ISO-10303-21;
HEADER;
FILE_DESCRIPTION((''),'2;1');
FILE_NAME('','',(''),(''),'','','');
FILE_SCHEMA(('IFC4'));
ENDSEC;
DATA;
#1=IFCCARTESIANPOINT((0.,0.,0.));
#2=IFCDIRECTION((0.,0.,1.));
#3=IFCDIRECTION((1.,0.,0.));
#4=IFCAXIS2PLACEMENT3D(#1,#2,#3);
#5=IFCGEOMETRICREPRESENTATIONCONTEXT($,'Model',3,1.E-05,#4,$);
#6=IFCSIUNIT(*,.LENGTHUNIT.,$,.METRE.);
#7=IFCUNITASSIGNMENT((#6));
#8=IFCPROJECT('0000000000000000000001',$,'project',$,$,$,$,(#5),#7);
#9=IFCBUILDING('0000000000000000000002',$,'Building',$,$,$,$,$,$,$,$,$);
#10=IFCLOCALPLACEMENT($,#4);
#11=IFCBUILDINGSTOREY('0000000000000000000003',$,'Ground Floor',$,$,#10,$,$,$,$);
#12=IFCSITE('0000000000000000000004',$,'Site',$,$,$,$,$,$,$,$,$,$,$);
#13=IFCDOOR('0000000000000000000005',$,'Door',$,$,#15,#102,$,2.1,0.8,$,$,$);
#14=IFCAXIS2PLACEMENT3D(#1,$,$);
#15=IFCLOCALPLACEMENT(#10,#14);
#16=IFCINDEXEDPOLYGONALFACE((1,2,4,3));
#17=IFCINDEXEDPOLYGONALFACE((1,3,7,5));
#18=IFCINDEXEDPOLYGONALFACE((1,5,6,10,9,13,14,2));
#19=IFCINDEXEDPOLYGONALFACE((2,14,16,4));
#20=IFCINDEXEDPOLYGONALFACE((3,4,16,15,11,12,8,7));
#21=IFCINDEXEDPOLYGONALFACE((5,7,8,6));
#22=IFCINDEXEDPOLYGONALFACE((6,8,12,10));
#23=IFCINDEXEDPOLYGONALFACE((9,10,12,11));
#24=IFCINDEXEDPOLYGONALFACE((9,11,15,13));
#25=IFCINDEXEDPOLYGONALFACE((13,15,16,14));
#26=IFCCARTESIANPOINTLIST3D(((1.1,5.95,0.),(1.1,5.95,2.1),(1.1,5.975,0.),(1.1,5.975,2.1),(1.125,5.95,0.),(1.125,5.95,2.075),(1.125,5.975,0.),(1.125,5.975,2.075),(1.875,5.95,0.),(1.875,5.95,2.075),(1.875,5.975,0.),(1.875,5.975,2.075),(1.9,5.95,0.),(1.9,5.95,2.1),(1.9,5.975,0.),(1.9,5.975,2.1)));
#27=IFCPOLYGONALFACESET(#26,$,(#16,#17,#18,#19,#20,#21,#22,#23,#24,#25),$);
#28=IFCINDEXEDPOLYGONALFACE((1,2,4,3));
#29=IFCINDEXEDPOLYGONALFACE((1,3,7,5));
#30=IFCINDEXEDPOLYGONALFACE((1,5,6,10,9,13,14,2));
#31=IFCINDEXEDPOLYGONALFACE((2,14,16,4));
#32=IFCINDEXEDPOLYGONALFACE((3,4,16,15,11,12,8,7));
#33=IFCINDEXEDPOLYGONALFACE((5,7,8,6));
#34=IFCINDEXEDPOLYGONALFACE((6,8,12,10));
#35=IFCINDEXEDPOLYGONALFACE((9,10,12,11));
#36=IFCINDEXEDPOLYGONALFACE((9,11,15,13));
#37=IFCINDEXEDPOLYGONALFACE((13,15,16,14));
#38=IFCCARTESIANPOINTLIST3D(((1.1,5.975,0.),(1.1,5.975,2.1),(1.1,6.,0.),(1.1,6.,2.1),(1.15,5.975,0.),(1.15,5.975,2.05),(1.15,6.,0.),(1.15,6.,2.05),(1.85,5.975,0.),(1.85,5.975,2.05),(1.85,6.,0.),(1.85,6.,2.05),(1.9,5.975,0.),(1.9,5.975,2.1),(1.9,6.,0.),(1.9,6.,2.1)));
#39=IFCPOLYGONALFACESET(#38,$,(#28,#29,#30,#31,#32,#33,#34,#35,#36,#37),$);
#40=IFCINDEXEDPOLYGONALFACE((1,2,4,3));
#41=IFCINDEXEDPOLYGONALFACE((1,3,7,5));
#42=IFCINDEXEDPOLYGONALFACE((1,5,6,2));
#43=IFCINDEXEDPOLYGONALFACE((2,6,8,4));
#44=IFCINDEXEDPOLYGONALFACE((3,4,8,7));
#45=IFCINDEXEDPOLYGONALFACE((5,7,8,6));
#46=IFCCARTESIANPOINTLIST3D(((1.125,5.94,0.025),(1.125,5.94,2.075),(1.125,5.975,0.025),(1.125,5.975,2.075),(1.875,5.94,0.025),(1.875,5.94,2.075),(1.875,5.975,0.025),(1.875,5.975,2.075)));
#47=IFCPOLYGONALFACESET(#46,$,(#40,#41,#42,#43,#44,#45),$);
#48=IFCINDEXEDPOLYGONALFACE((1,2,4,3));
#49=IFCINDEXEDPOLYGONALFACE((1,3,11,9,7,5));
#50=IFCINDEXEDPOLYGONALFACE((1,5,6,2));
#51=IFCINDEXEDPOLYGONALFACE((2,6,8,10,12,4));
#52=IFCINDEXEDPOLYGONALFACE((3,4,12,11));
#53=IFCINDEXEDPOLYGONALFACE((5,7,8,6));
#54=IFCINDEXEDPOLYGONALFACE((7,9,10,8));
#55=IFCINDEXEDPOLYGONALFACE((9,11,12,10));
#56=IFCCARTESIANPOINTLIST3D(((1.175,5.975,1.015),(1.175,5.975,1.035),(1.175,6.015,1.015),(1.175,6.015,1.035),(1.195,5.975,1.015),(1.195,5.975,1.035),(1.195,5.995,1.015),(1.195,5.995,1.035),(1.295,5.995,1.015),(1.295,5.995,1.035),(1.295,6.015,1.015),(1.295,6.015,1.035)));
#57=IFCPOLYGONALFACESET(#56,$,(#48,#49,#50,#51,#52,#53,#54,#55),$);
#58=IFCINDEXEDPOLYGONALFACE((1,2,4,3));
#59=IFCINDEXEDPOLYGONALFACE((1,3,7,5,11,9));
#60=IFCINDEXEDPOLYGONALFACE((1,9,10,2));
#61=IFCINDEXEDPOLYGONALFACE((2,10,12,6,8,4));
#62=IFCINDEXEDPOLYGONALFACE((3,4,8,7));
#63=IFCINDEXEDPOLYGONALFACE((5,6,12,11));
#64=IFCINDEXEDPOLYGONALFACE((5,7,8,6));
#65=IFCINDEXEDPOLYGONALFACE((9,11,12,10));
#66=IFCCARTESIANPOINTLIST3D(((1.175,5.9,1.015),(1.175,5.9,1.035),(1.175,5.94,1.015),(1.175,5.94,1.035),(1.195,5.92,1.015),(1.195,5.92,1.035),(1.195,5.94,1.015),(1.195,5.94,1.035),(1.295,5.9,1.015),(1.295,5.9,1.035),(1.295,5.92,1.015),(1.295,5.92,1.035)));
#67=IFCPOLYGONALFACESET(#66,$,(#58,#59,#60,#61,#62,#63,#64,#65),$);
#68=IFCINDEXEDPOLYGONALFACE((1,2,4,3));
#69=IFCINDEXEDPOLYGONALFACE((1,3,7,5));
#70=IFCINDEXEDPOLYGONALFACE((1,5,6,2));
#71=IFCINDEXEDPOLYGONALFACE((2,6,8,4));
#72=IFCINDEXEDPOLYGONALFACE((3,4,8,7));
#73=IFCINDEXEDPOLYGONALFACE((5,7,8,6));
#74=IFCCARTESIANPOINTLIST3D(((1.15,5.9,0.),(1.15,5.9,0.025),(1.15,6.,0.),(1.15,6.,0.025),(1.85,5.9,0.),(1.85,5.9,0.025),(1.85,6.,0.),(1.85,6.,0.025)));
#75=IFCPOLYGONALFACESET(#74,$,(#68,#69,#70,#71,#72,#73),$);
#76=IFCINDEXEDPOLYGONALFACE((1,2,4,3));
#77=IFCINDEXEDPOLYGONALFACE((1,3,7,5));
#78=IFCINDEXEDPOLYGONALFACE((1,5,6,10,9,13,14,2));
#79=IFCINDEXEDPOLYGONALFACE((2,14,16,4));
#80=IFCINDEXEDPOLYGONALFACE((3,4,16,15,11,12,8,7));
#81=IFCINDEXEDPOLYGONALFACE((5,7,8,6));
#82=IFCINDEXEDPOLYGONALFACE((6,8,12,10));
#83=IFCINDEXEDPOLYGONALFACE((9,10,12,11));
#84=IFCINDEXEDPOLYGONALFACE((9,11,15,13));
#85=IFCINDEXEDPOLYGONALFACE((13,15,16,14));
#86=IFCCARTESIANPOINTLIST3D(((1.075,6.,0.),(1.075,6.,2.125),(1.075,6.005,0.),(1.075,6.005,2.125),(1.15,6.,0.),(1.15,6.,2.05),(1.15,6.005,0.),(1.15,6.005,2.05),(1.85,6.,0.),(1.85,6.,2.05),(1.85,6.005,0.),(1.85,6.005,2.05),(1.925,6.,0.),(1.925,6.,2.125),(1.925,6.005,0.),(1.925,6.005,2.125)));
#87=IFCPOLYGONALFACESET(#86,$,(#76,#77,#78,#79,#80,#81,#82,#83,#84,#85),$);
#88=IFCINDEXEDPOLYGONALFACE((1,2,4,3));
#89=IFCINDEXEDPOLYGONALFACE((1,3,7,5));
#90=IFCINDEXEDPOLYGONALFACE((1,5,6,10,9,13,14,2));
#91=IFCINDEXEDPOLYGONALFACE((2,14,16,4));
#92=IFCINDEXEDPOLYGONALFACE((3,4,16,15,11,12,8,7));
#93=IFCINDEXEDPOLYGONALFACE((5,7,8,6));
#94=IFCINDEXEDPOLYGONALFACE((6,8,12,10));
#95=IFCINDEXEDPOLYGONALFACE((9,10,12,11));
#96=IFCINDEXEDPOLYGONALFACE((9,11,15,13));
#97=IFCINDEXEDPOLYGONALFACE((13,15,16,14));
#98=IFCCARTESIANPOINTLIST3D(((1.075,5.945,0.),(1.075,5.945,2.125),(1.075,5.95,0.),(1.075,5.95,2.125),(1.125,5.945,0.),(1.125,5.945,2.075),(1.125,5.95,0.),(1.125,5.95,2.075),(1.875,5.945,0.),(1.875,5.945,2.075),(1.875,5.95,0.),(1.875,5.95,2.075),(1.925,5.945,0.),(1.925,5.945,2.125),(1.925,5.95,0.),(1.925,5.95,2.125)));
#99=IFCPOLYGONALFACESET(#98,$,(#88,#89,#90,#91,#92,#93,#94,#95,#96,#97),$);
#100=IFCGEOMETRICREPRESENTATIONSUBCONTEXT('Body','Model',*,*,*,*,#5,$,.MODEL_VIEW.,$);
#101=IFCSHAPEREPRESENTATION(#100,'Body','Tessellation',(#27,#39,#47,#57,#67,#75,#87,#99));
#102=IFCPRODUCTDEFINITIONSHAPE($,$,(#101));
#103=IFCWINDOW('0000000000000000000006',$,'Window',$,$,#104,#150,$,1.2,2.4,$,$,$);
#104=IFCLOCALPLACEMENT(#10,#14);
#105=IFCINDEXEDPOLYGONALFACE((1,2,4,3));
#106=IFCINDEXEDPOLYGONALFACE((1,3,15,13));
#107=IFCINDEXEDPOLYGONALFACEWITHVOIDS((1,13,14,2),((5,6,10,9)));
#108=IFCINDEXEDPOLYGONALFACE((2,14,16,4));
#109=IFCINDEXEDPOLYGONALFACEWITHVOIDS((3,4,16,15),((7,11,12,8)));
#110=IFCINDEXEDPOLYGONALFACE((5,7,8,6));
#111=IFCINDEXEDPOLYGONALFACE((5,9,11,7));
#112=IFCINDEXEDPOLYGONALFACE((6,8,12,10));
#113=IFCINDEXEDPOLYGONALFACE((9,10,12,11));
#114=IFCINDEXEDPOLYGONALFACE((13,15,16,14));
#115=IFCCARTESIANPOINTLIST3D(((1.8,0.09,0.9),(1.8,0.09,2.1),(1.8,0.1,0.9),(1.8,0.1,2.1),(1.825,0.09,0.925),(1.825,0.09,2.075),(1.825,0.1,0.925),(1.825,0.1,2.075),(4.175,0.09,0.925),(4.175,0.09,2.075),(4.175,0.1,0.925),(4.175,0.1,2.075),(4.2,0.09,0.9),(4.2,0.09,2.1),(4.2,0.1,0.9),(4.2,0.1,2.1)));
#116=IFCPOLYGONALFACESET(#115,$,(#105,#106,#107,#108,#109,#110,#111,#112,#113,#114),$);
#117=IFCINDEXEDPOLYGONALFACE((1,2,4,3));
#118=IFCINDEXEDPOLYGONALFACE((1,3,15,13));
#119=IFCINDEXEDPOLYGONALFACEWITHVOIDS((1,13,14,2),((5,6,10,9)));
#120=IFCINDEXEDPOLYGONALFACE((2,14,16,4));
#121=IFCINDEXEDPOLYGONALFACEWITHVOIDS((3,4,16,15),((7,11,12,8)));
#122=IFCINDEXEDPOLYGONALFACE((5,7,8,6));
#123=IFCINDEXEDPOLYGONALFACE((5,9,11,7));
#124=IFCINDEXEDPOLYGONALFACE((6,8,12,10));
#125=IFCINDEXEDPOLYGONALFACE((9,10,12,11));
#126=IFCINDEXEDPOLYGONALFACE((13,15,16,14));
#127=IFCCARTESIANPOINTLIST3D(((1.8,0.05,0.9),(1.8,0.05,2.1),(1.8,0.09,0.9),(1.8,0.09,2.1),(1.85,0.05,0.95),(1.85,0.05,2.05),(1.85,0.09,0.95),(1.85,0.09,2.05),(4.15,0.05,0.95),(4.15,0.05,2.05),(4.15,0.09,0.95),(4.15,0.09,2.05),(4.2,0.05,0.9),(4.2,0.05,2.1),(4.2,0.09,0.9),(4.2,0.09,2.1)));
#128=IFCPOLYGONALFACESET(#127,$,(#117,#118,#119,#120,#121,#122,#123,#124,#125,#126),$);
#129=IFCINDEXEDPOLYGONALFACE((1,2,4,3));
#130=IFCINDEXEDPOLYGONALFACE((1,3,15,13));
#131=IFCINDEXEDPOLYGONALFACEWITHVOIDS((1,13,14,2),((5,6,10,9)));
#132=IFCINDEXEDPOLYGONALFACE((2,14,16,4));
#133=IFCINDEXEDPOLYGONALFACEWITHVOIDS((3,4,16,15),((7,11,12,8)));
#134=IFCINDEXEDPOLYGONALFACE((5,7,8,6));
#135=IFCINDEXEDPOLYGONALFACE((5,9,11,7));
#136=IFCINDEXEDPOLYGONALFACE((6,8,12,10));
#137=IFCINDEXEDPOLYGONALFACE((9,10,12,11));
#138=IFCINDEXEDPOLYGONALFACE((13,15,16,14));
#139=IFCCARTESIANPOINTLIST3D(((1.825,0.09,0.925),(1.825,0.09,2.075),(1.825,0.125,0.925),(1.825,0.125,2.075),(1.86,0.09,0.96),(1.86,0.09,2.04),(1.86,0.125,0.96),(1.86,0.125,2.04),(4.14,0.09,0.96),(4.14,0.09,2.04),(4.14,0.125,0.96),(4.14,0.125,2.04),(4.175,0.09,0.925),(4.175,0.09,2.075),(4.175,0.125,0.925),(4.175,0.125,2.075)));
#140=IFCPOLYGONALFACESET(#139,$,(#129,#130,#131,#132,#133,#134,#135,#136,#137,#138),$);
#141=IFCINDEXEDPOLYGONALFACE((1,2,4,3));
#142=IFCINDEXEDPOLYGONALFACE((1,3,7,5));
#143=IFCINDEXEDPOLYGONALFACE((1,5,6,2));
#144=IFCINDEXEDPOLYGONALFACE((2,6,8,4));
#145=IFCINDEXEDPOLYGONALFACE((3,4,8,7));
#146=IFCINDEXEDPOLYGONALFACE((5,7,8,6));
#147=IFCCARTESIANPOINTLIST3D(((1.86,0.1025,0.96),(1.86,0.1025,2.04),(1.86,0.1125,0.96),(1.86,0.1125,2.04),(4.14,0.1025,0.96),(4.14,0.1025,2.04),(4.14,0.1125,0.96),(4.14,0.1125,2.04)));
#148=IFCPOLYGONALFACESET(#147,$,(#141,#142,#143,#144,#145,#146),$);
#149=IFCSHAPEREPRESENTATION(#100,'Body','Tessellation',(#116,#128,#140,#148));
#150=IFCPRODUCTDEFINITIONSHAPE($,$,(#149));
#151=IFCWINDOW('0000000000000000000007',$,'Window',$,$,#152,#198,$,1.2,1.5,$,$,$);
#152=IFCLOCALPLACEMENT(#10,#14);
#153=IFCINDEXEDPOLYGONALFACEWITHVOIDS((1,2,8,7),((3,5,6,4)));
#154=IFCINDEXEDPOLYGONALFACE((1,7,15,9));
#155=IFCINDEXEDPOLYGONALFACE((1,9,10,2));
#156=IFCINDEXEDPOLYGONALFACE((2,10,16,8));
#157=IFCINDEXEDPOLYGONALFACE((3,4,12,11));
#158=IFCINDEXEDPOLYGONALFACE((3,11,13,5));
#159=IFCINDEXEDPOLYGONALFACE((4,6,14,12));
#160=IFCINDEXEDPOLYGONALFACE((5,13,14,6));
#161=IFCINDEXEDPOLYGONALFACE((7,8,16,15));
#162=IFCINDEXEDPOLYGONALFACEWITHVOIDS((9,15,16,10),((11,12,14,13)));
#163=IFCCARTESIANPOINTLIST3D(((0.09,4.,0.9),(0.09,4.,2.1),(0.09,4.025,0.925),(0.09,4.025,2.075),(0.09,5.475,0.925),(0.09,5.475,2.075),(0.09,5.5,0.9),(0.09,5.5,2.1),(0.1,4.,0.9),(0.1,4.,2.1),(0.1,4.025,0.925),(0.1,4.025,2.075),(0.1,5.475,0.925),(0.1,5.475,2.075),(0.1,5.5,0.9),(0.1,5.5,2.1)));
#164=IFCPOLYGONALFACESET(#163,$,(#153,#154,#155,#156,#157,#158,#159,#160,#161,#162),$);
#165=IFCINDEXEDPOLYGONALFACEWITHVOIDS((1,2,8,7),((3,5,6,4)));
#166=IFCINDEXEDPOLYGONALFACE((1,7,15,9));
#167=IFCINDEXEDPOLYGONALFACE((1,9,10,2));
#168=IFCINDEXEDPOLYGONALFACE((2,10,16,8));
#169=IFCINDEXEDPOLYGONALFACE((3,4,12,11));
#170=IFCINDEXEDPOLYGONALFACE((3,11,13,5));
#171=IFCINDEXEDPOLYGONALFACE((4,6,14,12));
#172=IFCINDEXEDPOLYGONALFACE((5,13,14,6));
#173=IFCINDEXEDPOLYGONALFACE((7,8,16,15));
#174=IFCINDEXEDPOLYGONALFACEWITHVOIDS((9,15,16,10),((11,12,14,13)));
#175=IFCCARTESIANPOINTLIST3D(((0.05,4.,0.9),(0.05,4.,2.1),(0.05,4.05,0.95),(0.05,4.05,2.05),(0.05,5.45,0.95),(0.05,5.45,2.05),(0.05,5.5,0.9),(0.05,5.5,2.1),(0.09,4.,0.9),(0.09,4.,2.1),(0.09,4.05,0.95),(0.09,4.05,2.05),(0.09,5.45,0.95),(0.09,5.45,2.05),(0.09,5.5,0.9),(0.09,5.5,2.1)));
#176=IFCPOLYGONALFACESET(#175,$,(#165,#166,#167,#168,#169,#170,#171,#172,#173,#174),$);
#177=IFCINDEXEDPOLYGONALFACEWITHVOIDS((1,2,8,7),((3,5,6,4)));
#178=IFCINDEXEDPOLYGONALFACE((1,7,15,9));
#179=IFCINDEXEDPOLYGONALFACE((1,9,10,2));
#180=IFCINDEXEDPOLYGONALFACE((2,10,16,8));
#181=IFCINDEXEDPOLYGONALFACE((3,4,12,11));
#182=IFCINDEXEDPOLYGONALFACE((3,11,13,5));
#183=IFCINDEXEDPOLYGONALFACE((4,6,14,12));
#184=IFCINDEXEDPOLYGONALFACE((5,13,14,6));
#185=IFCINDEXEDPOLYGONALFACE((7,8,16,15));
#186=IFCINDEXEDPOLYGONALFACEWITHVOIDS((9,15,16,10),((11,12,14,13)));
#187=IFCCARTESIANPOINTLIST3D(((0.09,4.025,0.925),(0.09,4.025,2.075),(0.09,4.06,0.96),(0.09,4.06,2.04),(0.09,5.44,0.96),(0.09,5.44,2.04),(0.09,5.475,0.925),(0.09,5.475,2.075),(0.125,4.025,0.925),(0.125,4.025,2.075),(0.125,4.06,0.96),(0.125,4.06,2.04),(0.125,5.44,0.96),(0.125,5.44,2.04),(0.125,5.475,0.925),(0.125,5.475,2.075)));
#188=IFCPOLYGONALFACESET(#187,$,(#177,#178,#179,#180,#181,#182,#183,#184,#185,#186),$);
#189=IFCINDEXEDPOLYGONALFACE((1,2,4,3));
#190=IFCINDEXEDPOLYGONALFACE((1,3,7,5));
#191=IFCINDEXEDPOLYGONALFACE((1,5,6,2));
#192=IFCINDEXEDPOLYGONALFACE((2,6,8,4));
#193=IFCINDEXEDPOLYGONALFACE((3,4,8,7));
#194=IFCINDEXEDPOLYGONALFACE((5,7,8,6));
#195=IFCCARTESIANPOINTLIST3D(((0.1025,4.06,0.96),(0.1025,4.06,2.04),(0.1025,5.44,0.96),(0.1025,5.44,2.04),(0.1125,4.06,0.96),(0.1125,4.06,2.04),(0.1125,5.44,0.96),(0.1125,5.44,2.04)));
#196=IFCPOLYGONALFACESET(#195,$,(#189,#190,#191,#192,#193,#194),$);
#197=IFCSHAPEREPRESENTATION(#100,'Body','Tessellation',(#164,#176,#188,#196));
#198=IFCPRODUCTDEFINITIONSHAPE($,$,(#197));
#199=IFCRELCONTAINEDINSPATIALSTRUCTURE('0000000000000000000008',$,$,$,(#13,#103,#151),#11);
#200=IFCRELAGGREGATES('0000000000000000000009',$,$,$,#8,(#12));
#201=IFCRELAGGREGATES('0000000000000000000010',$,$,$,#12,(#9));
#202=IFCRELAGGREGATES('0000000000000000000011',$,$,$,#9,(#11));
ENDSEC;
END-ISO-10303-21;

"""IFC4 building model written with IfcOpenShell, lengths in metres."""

from ifc_helpers import new_model, si_unit, frame, origin_with_axes, place, context, subcontext, project, spatial, line, indexed_curve, outline, extrude, element, save


model = new_model("IFC4")

# Units and contexts
model_context = context("Model", 3, precision=1e-05, world=origin_with_axes())
body_context = subcontext(model_context, "Body", "Model", "MODEL_VIEW")
ifc_project = project(units=[si_unit("LENGTHUNIT", "METRE")], contexts=[model_context])

# Site, building, storey
site = spatial("IfcSite", under=ifc_project, Name="Site")
building = spatial("IfcBuilding", under=site, Name="Building")
storey_placement = place(None, origin_with_axes())
storey = spatial("IfcBuildingStorey", under=building, at=storey_placement, Name="Ground Floor")

# Door
door_1_placement = place(storey_placement, frame((1.9, 6.0, 0.0), z_axis=(0.0, 0.0, 1.0), x_axis=(-1.0, 0.0, 0.0)))
element("IfcDoor", 1, at=door_1_placement, inside=storey, Name="Door", OverallHeight=2.1, OverallWidth=0.8, context=body_context, shape_type="SweptSolid", body=[
    extrude(outline(indexed_curve([(0.0, 0.0), (0.0, 2.1), (0.8, 2.1), (0.8, 0.0), (0.775, 0.0), (0.775, 2.075), (0.025, 2.075), (0.025, 0.0)], segments=[line(1, 2, 3, 4, 5, 6, 7, 8, 1)])), frame((0.0, 0.025, 0.0), z_axis=(0.0, -1.0, 0.0), x_axis=(1.0, 0.0, 0.0)), (0.0, 0.0, -1.0), 0.025),
    extrude(outline(indexed_curve([(0.0, 0.0), (0.0, 2.1), (0.8, 2.1), (0.8, 0.0), (0.75, 0.0), (0.75, 2.05), (0.05, 2.05), (0.05, 0.0)], segments=[line(1, 2, 3, 4, 5, 6, 7, 8, 1)])), frame((0.0, 0.0, 0.0), z_axis=(0.0, -1.0, 0.0), x_axis=(1.0, 0.0, 0.0)), (0.0, 0.0, -1.0), 0.025),
    extrude(outline(indexed_curve([(0.0, 0.0), (0.75, 0.0), (0.75, 0.035), (0.0, 0.035)], segments=[line(1, 2, 3, 4, 1)])), frame((0.025, 0.025, 0.025), z_axis=(0.0, 0.0, 1.0), x_axis=(1.0, 0.0, 0.0)), (0.0, 0.0, 1.0), 2.05),
    extrude(outline(indexed_curve([(0.0, 0.0), (0.0, -0.04), (-0.12, -0.04), (-0.12, -0.02), (-0.02, -0.02), (-0.02, 0.0)], segments=[line(1, 2, 3, 4, 5, 6, 1)])), frame((0.725, 0.025, 1.015), z_axis=(0.0, 0.0, 1.0), x_axis=(1.0, 0.0, 0.0)), (0.0, 0.0, 1.0), 0.02),
    extrude(outline(indexed_curve([(0.0, 0.0), (0.0, 0.04), (-0.12, 0.04), (-0.12, 0.02), (-0.02, 0.02), (-0.02, 0.0)], segments=[line(1, 2, 3, 4, 5, 6, 1)])), frame((0.725, 0.06, 1.015), z_axis=(0.0, 0.0, 1.0), x_axis=(1.0, 0.0, 0.0)), (0.0, 0.0, 1.0), 0.02),
    extrude(outline(indexed_curve([(0.0, 0.0), (0.7, 0.0), (0.7, 0.1), (0.0, 0.1)], segments=[line(1, 2, 3, 4, 1)])), frame((0.05, 0.0, 0.0), z_axis=(0.0, 0.0, 1.0), x_axis=(1.0, 0.0, 0.0)), (0.0, 0.0, 1.0), 0.025),
    extrude(outline(indexed_curve([(0.0, 0.0), (0.0, 2.125), (0.85, 2.125), (0.85, 0.0), (0.775, 0.0), (0.775, 2.05), (0.075, 2.05), (0.075, 0.0)], segments=[line(1, 2, 3, 4, 5, 6, 7, 8, 1)])), frame((-0.025, -0.005, 0.0), z_axis=(0.0, -1.0, 0.0), x_axis=(1.0, 0.0, 0.0)), (0.0, 0.0, -1.0), 0.005),
    extrude(outline(indexed_curve([(0.0, 0.0), (0.0, 2.125), (0.85, 2.125), (0.85, 0.0), (0.8, 0.0), (0.8, 2.075), (0.05, 2.075), (0.05, 0.0)], segments=[line(1, 2, 3, 4, 5, 6, 7, 8, 1)])), frame((-0.025, 0.05, 0.0), z_axis=(0.0, -1.0, 0.0), x_axis=(1.0, 0.0, 0.0)), (0.0, 0.0, -1.0), 0.005),
])

# Windows
window_1_placement = place(storey_placement, frame((1.8, 0.0, 0.9), z_axis=(0.0, 0.0, 1.0), x_axis=(1.0, 0.0, 0.0)))
element("IfcWindow", 2, at=window_1_placement, inside=storey, Name="Window", OverallHeight=1.2, OverallWidth=2.4, context=body_context, shape_type="SweptSolid", body=[
    extrude(outline(indexed_curve([(0.0, 0.0), (2.4, 0.0), (2.4, 1.2), (0.0, 1.2)], segments=[line(1, 2, 3, 4, 1)]), holes=[indexed_curve([(0.025, 0.025), (2.375, 0.025), (2.375, 1.175), (0.025, 1.175)], segments=[line(1, 2, 3, 4, 1)])]), frame((0.0, 0.09, 0.0), z_axis=(0.0, -1.0, 0.0), x_axis=(1.0, 0.0, 0.0)), (0.0, 0.0, -1.0), 0.01),
    extrude(outline(indexed_curve([(0.0, 0.0), (2.4, 0.0), (2.4, 1.2), (0.0, 1.2)], segments=[line(1, 2, 3, 4, 1)]), holes=[indexed_curve([(0.05, 0.05), (2.35, 0.05), (2.35, 1.15), (0.05, 1.15)], segments=[line(1, 2, 3, 4, 1)])]), frame((0.0, 0.05, 0.0), z_axis=(0.0, -1.0, 0.0), x_axis=(1.0, 0.0, 0.0)), (0.0, 0.0, -1.0), 0.04),
    extrude(outline(indexed_curve([(0.0, 0.0), (2.35, 0.0), (2.35, 1.15), (0.0, 1.15)], segments=[line(1, 2, 3, 4, 1)]), holes=[indexed_curve([(0.035, 0.035), (2.315, 0.035), (2.315, 1.115), (0.035, 1.115)], segments=[line(1, 2, 3, 4, 1)])]), frame((0.025, 0.09, 0.025), z_axis=(0.0, -1.0, 0.0), x_axis=(1.0, 0.0, 0.0)), (0.0, 0.0, -1.0), 0.035),
    extrude(outline(indexed_curve([(0.035, 0.035), (2.315, 0.035), (2.315, 1.115), (0.035, 1.115)], segments=[line(1, 2, 3, 4, 1)])), frame((0.025, 0.1025, 0.025), z_axis=(0.0, -1.0, 0.0), x_axis=(1.0, 0.0, 0.0)), (0.0, 0.0, -1.0), 0.01),
])
window_2_placement = place(storey_placement, frame((0.0, 5.5, 0.9), z_axis=(0.0, 0.0, 1.0), x_axis=(0.0, -1.0, 0.0)))
element("IfcWindow", 3, at=window_2_placement, inside=storey, Name="Window", OverallHeight=1.2, OverallWidth=1.5, context=body_context, shape_type="SweptSolid", body=[
    extrude(outline(indexed_curve([(0.0, 0.0), (1.5, 0.0), (1.5, 1.2), (0.0, 1.2)], segments=[line(1, 2, 3, 4, 1)]), holes=[indexed_curve([(0.025, 0.025), (1.475, 0.025), (1.475, 1.175), (0.025, 1.175)], segments=[line(1, 2, 3, 4, 1)])]), frame((0.0, 0.09, 0.0), z_axis=(0.0, -1.0, 0.0), x_axis=(1.0, 0.0, 0.0)), (0.0, 0.0, -1.0), 0.01),
    extrude(outline(indexed_curve([(0.0, 0.0), (1.5, 0.0), (1.5, 1.2), (0.0, 1.2)], segments=[line(1, 2, 3, 4, 1)]), holes=[indexed_curve([(0.05, 0.05), (1.45, 0.05), (1.45, 1.15), (0.05, 1.15)], segments=[line(1, 2, 3, 4, 1)])]), frame((0.0, 0.05, 0.0), z_axis=(0.0, -1.0, 0.0), x_axis=(1.0, 0.0, 0.0)), (0.0, 0.0, -1.0), 0.04),
    extrude(outline(indexed_curve([(0.0, 0.0), (1.45, 0.0), (1.45, 1.15), (0.0, 1.15)], segments=[line(1, 2, 3, 4, 1)]), holes=[indexed_curve([(0.035, 0.035), (1.415, 0.035), (1.415, 1.115), (0.035, 1.115)], segments=[line(1, 2, 3, 4, 1)])]), frame((0.025, 0.09, 0.025), z_axis=(0.0, -1.0, 0.0), x_axis=(1.0, 0.0, 0.0)), (0.0, 0.0, -1.0), 0.035),
    extrude(outline(indexed_curve([(0.035, 0.035), (1.415, 0.035), (1.415, 1.115), (0.035, 1.115)], segments=[line(1, 2, 3, 4, 1)])), frame((0.025, 0.1025, 0.025), z_axis=(0.0, -1.0, 0.0), x_axis=(1.0, 0.0, 0.0)), (0.0, 0.0, -1.0), 0.01),
])

save(model, "model.ifc")
